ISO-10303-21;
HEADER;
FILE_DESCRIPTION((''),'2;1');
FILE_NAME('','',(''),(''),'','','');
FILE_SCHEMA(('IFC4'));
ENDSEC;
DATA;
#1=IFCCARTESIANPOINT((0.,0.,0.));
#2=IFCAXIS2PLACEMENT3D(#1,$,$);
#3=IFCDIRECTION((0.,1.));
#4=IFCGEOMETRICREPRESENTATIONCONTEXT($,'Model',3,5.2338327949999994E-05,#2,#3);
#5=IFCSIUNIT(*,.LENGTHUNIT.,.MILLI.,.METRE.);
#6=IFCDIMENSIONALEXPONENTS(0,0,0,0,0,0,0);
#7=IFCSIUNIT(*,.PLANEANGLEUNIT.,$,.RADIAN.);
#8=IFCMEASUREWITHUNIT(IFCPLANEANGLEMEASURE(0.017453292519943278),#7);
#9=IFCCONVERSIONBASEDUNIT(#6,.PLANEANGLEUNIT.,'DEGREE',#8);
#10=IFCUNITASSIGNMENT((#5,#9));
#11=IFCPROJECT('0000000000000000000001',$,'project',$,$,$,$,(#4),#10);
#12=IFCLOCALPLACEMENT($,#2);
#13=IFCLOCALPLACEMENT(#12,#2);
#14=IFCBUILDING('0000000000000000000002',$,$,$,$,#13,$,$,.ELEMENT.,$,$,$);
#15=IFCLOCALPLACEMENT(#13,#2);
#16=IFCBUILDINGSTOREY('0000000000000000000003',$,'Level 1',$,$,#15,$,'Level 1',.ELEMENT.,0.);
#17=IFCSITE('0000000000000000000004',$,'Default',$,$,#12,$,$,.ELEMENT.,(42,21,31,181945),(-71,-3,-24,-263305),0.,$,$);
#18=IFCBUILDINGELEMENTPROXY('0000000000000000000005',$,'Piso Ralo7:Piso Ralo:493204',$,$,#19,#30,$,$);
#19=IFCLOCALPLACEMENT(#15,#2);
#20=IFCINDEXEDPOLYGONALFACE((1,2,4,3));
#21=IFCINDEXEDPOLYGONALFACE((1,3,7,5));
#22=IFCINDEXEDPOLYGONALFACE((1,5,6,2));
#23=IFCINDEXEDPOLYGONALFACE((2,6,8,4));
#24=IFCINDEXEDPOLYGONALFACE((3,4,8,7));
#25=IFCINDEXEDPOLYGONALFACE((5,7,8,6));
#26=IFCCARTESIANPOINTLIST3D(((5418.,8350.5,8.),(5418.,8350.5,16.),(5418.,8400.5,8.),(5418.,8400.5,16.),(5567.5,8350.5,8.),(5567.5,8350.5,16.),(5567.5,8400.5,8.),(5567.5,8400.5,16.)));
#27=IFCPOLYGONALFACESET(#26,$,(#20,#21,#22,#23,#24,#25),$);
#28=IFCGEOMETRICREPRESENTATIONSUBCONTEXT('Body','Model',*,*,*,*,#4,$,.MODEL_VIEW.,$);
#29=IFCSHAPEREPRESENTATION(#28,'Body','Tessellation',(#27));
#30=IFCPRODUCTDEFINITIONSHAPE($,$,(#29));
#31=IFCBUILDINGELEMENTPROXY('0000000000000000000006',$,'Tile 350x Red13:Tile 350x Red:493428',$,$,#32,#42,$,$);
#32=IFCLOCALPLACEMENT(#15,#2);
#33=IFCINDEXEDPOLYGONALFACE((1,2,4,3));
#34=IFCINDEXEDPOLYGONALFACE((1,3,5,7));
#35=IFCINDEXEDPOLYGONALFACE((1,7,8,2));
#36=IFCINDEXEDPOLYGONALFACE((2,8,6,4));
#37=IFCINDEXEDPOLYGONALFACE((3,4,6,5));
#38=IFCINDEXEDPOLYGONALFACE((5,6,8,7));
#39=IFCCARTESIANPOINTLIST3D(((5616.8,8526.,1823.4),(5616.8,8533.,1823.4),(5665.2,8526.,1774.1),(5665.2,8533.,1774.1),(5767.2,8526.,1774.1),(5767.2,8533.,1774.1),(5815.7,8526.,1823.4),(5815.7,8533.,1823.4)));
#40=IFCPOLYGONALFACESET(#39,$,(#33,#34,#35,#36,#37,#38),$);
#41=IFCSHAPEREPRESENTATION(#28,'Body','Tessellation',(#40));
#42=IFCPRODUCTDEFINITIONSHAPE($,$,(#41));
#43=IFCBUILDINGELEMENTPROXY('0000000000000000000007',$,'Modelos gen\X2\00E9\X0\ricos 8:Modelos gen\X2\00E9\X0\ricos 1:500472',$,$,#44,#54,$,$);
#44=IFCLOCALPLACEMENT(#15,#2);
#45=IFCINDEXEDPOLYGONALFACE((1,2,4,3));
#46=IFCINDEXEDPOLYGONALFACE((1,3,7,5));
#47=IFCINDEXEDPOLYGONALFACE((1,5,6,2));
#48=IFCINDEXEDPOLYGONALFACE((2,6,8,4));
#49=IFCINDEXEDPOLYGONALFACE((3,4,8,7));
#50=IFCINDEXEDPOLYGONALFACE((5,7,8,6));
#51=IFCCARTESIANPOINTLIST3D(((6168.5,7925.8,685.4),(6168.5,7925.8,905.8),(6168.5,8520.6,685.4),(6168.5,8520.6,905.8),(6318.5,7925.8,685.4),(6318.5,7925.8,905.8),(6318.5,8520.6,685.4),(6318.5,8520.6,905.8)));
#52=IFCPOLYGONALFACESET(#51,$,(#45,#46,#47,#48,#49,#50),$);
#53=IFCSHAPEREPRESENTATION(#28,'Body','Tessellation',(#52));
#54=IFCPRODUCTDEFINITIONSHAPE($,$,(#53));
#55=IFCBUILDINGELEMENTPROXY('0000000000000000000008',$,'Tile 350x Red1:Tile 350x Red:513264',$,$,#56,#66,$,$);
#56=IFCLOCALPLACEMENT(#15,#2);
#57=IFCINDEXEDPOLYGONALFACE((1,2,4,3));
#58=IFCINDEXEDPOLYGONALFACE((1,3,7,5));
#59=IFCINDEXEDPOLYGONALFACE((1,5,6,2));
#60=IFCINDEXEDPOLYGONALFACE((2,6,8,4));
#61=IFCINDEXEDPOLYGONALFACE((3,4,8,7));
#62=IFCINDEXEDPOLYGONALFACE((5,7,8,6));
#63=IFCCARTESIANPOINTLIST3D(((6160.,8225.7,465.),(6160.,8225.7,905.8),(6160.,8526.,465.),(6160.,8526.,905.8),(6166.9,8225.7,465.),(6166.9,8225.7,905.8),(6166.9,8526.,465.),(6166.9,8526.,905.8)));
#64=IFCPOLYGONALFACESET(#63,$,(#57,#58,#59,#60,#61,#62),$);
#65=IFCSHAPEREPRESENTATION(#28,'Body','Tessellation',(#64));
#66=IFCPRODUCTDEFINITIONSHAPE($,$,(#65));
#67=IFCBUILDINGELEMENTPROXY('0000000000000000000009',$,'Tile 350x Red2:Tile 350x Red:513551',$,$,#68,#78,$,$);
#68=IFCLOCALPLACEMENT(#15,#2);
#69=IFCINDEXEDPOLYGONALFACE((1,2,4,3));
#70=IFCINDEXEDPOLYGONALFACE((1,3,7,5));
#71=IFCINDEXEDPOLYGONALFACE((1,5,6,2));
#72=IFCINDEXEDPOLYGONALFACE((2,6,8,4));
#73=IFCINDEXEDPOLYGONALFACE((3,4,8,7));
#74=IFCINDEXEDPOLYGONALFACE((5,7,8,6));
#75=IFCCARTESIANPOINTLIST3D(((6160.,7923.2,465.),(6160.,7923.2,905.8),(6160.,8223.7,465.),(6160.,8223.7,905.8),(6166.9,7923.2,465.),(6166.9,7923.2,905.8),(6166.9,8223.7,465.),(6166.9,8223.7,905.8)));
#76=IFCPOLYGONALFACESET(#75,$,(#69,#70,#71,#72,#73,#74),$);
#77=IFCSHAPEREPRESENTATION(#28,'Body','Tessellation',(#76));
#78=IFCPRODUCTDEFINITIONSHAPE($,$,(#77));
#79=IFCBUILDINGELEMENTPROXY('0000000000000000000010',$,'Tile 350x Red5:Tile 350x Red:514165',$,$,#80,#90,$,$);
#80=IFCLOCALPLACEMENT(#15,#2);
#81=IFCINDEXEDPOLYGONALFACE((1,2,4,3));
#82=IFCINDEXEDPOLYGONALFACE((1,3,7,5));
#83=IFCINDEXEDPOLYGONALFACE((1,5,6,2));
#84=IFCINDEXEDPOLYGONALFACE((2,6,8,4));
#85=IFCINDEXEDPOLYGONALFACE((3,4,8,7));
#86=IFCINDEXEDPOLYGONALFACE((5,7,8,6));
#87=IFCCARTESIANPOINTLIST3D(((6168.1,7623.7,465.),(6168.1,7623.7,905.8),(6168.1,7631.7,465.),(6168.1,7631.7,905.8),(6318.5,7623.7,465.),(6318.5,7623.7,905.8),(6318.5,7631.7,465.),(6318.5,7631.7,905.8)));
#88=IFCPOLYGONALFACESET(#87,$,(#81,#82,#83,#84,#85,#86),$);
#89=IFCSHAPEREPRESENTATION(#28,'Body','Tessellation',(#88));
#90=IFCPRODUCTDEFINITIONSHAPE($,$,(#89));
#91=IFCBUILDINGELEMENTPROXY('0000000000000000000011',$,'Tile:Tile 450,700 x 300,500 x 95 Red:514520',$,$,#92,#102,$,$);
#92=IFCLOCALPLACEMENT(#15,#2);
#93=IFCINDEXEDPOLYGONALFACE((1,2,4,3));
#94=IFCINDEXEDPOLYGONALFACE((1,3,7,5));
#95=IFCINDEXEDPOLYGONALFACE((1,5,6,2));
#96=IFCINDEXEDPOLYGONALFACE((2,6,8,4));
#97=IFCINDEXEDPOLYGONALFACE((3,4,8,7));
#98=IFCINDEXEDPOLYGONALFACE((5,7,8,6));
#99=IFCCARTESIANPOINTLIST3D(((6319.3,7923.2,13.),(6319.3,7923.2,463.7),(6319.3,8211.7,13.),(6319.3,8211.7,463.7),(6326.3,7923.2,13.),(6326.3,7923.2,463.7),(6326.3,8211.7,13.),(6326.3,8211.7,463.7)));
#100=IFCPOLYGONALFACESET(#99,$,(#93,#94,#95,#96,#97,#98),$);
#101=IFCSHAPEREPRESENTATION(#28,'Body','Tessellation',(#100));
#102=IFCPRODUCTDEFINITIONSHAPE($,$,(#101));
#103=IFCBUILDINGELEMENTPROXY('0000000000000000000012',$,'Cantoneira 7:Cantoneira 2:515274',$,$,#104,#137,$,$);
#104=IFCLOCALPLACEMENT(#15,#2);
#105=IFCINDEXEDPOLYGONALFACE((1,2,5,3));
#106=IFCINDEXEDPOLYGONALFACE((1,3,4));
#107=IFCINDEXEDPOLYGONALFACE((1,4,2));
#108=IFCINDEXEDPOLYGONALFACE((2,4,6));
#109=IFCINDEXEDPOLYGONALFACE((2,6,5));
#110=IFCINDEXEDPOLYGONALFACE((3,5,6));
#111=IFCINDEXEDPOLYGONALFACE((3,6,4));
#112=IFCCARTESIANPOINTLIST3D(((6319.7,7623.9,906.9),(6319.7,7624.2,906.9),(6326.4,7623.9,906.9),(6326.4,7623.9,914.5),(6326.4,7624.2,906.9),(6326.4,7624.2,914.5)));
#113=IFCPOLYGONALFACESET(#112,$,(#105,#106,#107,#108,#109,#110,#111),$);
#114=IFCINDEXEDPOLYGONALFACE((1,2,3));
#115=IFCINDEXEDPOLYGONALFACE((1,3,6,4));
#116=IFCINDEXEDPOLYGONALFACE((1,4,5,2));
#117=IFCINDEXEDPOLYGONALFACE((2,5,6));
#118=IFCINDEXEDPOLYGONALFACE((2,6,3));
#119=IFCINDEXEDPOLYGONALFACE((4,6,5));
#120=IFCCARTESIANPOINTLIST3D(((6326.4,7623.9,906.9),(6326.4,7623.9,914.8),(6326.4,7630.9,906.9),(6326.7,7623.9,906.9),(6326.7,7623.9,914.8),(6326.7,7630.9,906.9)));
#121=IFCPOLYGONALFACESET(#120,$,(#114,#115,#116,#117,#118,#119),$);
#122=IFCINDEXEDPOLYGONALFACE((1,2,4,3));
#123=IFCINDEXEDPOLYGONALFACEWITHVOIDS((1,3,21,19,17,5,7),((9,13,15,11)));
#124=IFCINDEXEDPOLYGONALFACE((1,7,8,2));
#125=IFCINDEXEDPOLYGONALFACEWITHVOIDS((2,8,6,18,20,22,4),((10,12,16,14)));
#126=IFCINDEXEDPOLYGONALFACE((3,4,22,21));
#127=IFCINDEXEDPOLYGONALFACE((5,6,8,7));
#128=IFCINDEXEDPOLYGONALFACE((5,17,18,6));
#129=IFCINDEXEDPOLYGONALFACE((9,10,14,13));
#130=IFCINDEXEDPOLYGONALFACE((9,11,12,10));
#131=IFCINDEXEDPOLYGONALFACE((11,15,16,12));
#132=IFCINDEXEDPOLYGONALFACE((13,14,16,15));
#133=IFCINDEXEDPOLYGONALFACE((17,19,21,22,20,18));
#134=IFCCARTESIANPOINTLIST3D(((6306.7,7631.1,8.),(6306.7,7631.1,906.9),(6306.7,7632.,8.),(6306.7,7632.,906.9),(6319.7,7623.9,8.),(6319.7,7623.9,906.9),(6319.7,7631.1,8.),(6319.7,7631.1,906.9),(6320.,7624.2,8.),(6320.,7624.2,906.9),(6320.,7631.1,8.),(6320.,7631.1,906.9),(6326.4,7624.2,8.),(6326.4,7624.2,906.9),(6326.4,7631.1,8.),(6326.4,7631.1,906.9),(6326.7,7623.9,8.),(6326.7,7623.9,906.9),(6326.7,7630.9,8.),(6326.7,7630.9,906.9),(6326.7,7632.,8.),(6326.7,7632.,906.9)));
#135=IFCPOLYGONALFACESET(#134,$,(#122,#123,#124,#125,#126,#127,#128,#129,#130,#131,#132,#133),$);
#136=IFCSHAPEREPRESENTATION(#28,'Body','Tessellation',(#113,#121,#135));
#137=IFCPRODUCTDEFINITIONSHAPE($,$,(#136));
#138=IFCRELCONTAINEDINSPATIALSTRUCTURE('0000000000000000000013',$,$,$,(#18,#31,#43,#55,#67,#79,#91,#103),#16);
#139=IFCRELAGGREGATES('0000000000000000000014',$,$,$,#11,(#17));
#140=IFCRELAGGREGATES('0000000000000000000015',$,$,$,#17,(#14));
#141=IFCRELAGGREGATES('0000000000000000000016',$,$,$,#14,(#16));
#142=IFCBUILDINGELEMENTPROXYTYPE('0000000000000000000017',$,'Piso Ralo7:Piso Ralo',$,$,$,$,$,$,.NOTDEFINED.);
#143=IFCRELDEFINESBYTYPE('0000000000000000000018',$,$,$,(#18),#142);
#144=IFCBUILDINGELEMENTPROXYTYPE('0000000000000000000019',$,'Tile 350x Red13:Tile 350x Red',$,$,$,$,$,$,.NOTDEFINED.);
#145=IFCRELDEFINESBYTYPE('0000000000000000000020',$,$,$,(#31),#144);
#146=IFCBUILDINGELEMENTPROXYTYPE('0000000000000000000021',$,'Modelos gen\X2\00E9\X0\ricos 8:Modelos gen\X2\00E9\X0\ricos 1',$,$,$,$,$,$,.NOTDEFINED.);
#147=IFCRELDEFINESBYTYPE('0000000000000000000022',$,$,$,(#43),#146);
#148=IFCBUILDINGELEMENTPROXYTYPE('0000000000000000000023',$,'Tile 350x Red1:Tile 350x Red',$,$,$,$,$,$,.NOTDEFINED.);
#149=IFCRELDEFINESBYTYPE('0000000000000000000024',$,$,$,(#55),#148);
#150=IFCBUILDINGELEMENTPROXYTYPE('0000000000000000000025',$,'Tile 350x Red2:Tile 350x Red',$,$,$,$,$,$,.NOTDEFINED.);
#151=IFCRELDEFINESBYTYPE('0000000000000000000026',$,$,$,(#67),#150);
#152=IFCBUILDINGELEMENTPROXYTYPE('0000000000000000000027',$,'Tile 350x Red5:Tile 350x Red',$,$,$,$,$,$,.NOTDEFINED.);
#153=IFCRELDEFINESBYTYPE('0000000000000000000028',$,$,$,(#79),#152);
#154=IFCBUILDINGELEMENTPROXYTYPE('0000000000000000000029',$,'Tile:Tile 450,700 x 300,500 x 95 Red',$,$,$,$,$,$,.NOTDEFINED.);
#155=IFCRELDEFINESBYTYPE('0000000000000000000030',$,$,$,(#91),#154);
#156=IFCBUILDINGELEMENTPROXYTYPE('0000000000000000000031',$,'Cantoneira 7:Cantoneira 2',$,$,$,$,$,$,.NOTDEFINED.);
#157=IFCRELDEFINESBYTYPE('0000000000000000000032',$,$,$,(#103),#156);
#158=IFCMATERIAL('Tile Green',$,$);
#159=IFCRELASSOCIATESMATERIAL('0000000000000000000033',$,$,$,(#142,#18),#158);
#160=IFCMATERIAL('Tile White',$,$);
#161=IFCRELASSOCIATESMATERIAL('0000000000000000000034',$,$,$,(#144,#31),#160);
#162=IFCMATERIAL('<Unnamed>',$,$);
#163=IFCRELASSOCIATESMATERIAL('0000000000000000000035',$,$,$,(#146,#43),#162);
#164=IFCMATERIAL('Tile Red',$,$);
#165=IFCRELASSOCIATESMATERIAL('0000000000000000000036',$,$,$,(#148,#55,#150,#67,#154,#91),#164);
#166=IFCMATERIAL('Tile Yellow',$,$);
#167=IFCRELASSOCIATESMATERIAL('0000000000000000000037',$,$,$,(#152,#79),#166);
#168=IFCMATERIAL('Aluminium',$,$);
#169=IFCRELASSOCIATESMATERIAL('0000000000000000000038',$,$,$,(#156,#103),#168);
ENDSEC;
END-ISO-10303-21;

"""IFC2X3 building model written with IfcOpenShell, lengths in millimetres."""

from ifc_helpers import new_model, entity, si_unit, converted_unit, direction, frame, frame_2d, origin, origin_2d_with_axis, place, context, subcontext, project, spatial, polyline, rectangle, outline, extrude, source, transform, mapped, material, type_object, type_shapes, element, save


model = new_model("IFC2X3")

# Units and contexts
model_context = context("Model", 3, precision=5.2338327949999994e-05, world=origin(), true_north=direction((0.0, 1.0)))
body_context = subcontext(model_context, "Body", "Model", "MODEL_VIEW")
ifc_project = project(units=[si_unit("LENGTHUNIT", "METRE", prefix="MILLI"), converted_unit("PLANEANGLEUNIT", "DEGREE", entity("IfcPlaneAngleMeasure", 0.017453292519943278), si_unit("PLANEANGLEUNIT", "RADIAN"), dimensions=[0, 0, 0, 0, 0, 0, 0])], contexts=[model_context])

# Site, building, storey
site_placement = place(None, origin())
site = spatial("IfcSite", under=ifc_project, at=site_placement, Name="Default", CompositionType="ELEMENT", RefLatitude=(42, 21, 31, 181945), RefLongitude=(-71, -3, -24, -263305), RefElevation=0.0)
building_placement = place(site_placement, origin())
building = spatial("IfcBuilding", under=site, at=building_placement, CompositionType="ELEMENT")
storey_placement = place(building_placement, origin())
storey = spatial("IfcBuildingStorey", under=building, at=storey_placement, Name="Level 1", LongName="Level 1", CompositionType="ELEMENT", Elevation=0.0)

# Building element proxies
ifc_material_1 = material(Name="Tile Green")
building_element_proxy_type_1 = type_object("IfcBuildingElementProxyType", Name="Piso Ralo7:Piso Ralo", PredefinedType="NOTDEFINED", material=ifc_material_1)
shared_shape_1 = source(origin(), body_context, "Body", "SweptSolid", [
    extrude(rectangle(XDim=149.5, YDim=50.0, at=frame_2d((0.0, 0.0), x_axis=(1.0, 0.0))), frame((5492.7, 8375.5, 8.0), z_axis=(0.0, 0.0, 1.0), x_axis=(-1.0, 0.0, 0.0)), (0.0, 0.0, 1.0), 8.0),
])
type_shapes(building_element_proxy_type_1, [shared_shape_1])
proxy_1_placement = place(storey_placement, origin())
element("IfcBuildingElementProxy", 1, at=proxy_1_placement, inside=storey, type_object=building_element_proxy_type_1, material=ifc_material_1, Name="Piso Ralo7:Piso Ralo:493204", context=body_context, shape_type="MappedRepresentation", body=[
    mapped(shared_shape_1, transform((0.0, 0.0, 0.0), scale=1.0)),
])
ifc_material_2 = material(Name="Tile Red")
ifc_material_3 = material(Name="Tile White")
building_element_proxy_type_2 = type_object("IfcBuildingElementProxyType", Name="Tile 350x Red13:Tile 350x Red", PredefinedType="NOTDEFINED", material=ifc_material_3)
shared_shape_2 = source(origin(), body_context, "Body", "SweptSolid", [
    extrude(outline(polyline([(-99.4, -24.7), (99.4, -24.7), (51.0, 24.7), (-51.0, 24.7), (-99.4, -24.7)])), frame((5716.2, 8526.0, 1798.7), z_axis=(0.0, 1.0, 0.0), x_axis=(1.0, 0.0, 0.0)), (0.0, 0.0, 1.0), 7.0),
])
type_shapes(building_element_proxy_type_2, [shared_shape_2])
proxy_2_placement = place(storey_placement, origin())
element("IfcBuildingElementProxy", 2, at=proxy_2_placement, inside=storey, type_object=building_element_proxy_type_2, material=ifc_material_3, Name="Tile 350x Red13:Tile 350x Red:493428", context=body_context, shape_type="MappedRepresentation", body=[
    mapped(shared_shape_2, transform((0.0, 0.0, 0.0), scale=1.0)),
])
ifc_material_4 = material(Name="<Unnamed>")
building_element_proxy_type_3 = type_object("IfcBuildingElementProxyType", Name="Modelos genéricos 8:Modelos genéricos 1", PredefinedType="NOTDEFINED", material=ifc_material_4)
shared_shape_3 = source(origin(), body_context, "Body", "SweptSolid", [
    extrude(rectangle(XDim=594.8, YDim=150.0, at=origin_2d_with_axis()), frame((6243.5, 8223.2, 685.4), z_axis=(0.0, 0.0, 1.0), x_axis=(0.0, 1.0, 0.0)), (0.0, 0.0, 1.0), 220.4),
])
type_shapes(building_element_proxy_type_3, [shared_shape_3])
proxy_3_placement = place(storey_placement, origin())
element("IfcBuildingElementProxy", 3, at=proxy_3_placement, inside=storey, type_object=building_element_proxy_type_3, material=ifc_material_4, Name="Modelos genéricos 8:Modelos genéricos 1:500472", context=body_context, shape_type="MappedRepresentation", body=[
    mapped(shared_shape_3, transform((0.0, 0.0, 0.0), scale=1.0)),
])
ifc_material_5 = material(Name="Aluminium")
building_element_proxy_type_4 = type_object("IfcBuildingElementProxyType", Name="Tile 350x Red1:Tile 350x Red", PredefinedType="NOTDEFINED", material=ifc_material_2)
shared_shape_4 = source(origin(), body_context, "Body", "SweptSolid", [
    extrude(rectangle(XDim=6.9, YDim=300.3, at=frame_2d((0.0, 0.0), x_axis=(1.0, 0.0))), frame((6163.4, 8375.9, 465.0), z_axis=(0.0, 0.0, 1.0), x_axis=(-1.0, 0.0, 0.0)), (0.0, 0.0, 1.0), 440.8),
])
type_shapes(building_element_proxy_type_4, [shared_shape_4])
proxy_4_placement = place(storey_placement, origin())
element("IfcBuildingElementProxy", 4, at=proxy_4_placement, inside=storey, type_object=building_element_proxy_type_4, material=ifc_material_2, Name="Tile 350x Red1:Tile 350x Red:513264", context=body_context, shape_type="MappedRepresentation", body=[
    mapped(shared_shape_4, transform((0.0, 0.0, 0.0), scale=1.0)),
])
building_element_proxy_type_5 = type_object("IfcBuildingElementProxyType", Name="Tile 350x Red2:Tile 350x Red", PredefinedType="NOTDEFINED", material=ifc_material_2)
shared_shape_5 = source(origin(), body_context, "Body", "SweptSolid", [
    extrude(rectangle(XDim=6.9, YDim=300.5, at=frame_2d((0.0, 0.0), x_axis=(1.0, 0.0))), frame((6163.4, 8073.4, 465.0), z_axis=(0.0, 0.0, 1.0), x_axis=(-1.0, 0.0, 0.0)), (0.0, 0.0, 1.0), 440.8),
])
type_shapes(building_element_proxy_type_5, [shared_shape_5])
proxy_5_placement = place(storey_placement, origin())
element("IfcBuildingElementProxy", 5, at=proxy_5_placement, inside=storey, type_object=building_element_proxy_type_5, material=ifc_material_2, Name="Tile 350x Red2:Tile 350x Red:513551", context=body_context, shape_type="MappedRepresentation", body=[
    mapped(shared_shape_5, transform((0.0, 0.0, 0.0), scale=1.0)),
])
ifc_material_6 = material(Name="Tile Yellow")
building_element_proxy_type_6 = type_object("IfcBuildingElementProxyType", Name="Tile 350x Red5:Tile 350x Red", PredefinedType="NOTDEFINED", material=ifc_material_6)
shared_shape_6 = source(origin(), body_context, "Body", "SweptSolid", [
    extrude(rectangle(XDim=8.0, YDim=150.5, at=frame_2d((0.0, 0.0), x_axis=(1.0, 0.0))), frame((6243.3, 7627.7, 465.0), z_axis=(0.0, 0.0, 1.0), x_axis=(0.0, -1.0, 0.0)), (0.0, 0.0, 1.0), 440.8),
])
type_shapes(building_element_proxy_type_6, [shared_shape_6])
proxy_6_placement = place(storey_placement, origin())
element("IfcBuildingElementProxy", 6, at=proxy_6_placement, inside=storey, type_object=building_element_proxy_type_6, material=ifc_material_6, Name="Tile 350x Red5:Tile 350x Red:514165", context=body_context, shape_type="MappedRepresentation", body=[
    mapped(shared_shape_6, transform((0.0, 0.0, 0.0), scale=1.0)),
])
building_element_proxy_type_7 = type_object("IfcBuildingElementProxyType", Name="Tile:Tile 450,700 x 300,500 x 95 Red", PredefinedType="NOTDEFINED", material=ifc_material_2)
shared_shape_7 = source(origin(), body_context, "Body", "SweptSolid", [
    extrude(rectangle(XDim=288.5, YDim=7.0, at=frame_2d((0.0, 0.0), x_axis=(1.0, 0.0))), frame((6322.8, 8067.4, 13.0), z_axis=(0.0, 0.0, 1.0), x_axis=(0.0, 1.0, 0.0)), (0.0, 0.0, 1.0), 450.7),
])
type_shapes(building_element_proxy_type_7, [shared_shape_7])
proxy_7_placement = place(storey_placement, origin())
element("IfcBuildingElementProxy", 7, at=proxy_7_placement, inside=storey, type_object=building_element_proxy_type_7, material=ifc_material_2, Name="Tile:Tile 450,700 x 300,500 x 95 Red:514520", context=body_context, shape_type="MappedRepresentation", body=[
    mapped(shared_shape_7, transform((0.0, 0.0, 0.0), scale=1.0)),
])
building_element_proxy_type_8 = type_object("IfcBuildingElementProxyType", Name="Cantoneira 7:Cantoneira 2", PredefinedType="NOTDEFINED", material=ifc_material_5)
shared_shape_8 = source(origin(), body_context, "Body", "SweptSolid", [
    extrude(outline(polyline([(-2.2, -2.5), (4.5, -2.5), (-2.2, 5.0), (-2.2, -2.5)])), frame((6324.2, 7623.9, 909.4), z_axis=(0.0, 1.0, 0.0), x_axis=(-1.0, 0.0, 0.0)), (0.0, 0.0, 1.0), 0.3),
    extrude(outline(polyline([(-5.1, -1.8), (5.5, -1.8), (-0.4, 3.5), (-5.1, -1.8)])), frame((6326.4, 7626.2, 909.6), z_axis=(1.0, 0.0, 0.0), x_axis=(0.0, -0.664803, 0.747019)), (0.0, 0.0, 1.0), 0.3),
    extrude(outline(polyline([(1.6, -7.7), (2.8, -7.7), (2.8, 12.3), (1.8, 12.3), (1.8, -0.7), (-5.4, -0.7), (-5.4, -7.7), (1.6, -7.7)]), holes=[polyline([(-5.1, -1.0), (1.8, -1.0), (1.8, -7.4), (-5.1, -7.4), (-5.1, -1.0)])]), frame((6319.0, 7629.3, 8.0), z_axis=(0.0, 0.0, 1.0), x_axis=(0.0, 1.0, 0.0)), (0.0, 0.0, 1.0), 898.9),
])
type_shapes(building_element_proxy_type_8, [shared_shape_8])
proxy_8_placement = place(storey_placement, origin())
element("IfcBuildingElementProxy", 8, at=proxy_8_placement, inside=storey, type_object=building_element_proxy_type_8, material=ifc_material_5, Name="Cantoneira 7:Cantoneira 2:515274", context=body_context, shape_type="MappedRepresentation", body=[
    mapped(shared_shape_8, transform((0.0, 0.0, 0.0), scale=1.0)),
])

save(model, "model.ifc")
